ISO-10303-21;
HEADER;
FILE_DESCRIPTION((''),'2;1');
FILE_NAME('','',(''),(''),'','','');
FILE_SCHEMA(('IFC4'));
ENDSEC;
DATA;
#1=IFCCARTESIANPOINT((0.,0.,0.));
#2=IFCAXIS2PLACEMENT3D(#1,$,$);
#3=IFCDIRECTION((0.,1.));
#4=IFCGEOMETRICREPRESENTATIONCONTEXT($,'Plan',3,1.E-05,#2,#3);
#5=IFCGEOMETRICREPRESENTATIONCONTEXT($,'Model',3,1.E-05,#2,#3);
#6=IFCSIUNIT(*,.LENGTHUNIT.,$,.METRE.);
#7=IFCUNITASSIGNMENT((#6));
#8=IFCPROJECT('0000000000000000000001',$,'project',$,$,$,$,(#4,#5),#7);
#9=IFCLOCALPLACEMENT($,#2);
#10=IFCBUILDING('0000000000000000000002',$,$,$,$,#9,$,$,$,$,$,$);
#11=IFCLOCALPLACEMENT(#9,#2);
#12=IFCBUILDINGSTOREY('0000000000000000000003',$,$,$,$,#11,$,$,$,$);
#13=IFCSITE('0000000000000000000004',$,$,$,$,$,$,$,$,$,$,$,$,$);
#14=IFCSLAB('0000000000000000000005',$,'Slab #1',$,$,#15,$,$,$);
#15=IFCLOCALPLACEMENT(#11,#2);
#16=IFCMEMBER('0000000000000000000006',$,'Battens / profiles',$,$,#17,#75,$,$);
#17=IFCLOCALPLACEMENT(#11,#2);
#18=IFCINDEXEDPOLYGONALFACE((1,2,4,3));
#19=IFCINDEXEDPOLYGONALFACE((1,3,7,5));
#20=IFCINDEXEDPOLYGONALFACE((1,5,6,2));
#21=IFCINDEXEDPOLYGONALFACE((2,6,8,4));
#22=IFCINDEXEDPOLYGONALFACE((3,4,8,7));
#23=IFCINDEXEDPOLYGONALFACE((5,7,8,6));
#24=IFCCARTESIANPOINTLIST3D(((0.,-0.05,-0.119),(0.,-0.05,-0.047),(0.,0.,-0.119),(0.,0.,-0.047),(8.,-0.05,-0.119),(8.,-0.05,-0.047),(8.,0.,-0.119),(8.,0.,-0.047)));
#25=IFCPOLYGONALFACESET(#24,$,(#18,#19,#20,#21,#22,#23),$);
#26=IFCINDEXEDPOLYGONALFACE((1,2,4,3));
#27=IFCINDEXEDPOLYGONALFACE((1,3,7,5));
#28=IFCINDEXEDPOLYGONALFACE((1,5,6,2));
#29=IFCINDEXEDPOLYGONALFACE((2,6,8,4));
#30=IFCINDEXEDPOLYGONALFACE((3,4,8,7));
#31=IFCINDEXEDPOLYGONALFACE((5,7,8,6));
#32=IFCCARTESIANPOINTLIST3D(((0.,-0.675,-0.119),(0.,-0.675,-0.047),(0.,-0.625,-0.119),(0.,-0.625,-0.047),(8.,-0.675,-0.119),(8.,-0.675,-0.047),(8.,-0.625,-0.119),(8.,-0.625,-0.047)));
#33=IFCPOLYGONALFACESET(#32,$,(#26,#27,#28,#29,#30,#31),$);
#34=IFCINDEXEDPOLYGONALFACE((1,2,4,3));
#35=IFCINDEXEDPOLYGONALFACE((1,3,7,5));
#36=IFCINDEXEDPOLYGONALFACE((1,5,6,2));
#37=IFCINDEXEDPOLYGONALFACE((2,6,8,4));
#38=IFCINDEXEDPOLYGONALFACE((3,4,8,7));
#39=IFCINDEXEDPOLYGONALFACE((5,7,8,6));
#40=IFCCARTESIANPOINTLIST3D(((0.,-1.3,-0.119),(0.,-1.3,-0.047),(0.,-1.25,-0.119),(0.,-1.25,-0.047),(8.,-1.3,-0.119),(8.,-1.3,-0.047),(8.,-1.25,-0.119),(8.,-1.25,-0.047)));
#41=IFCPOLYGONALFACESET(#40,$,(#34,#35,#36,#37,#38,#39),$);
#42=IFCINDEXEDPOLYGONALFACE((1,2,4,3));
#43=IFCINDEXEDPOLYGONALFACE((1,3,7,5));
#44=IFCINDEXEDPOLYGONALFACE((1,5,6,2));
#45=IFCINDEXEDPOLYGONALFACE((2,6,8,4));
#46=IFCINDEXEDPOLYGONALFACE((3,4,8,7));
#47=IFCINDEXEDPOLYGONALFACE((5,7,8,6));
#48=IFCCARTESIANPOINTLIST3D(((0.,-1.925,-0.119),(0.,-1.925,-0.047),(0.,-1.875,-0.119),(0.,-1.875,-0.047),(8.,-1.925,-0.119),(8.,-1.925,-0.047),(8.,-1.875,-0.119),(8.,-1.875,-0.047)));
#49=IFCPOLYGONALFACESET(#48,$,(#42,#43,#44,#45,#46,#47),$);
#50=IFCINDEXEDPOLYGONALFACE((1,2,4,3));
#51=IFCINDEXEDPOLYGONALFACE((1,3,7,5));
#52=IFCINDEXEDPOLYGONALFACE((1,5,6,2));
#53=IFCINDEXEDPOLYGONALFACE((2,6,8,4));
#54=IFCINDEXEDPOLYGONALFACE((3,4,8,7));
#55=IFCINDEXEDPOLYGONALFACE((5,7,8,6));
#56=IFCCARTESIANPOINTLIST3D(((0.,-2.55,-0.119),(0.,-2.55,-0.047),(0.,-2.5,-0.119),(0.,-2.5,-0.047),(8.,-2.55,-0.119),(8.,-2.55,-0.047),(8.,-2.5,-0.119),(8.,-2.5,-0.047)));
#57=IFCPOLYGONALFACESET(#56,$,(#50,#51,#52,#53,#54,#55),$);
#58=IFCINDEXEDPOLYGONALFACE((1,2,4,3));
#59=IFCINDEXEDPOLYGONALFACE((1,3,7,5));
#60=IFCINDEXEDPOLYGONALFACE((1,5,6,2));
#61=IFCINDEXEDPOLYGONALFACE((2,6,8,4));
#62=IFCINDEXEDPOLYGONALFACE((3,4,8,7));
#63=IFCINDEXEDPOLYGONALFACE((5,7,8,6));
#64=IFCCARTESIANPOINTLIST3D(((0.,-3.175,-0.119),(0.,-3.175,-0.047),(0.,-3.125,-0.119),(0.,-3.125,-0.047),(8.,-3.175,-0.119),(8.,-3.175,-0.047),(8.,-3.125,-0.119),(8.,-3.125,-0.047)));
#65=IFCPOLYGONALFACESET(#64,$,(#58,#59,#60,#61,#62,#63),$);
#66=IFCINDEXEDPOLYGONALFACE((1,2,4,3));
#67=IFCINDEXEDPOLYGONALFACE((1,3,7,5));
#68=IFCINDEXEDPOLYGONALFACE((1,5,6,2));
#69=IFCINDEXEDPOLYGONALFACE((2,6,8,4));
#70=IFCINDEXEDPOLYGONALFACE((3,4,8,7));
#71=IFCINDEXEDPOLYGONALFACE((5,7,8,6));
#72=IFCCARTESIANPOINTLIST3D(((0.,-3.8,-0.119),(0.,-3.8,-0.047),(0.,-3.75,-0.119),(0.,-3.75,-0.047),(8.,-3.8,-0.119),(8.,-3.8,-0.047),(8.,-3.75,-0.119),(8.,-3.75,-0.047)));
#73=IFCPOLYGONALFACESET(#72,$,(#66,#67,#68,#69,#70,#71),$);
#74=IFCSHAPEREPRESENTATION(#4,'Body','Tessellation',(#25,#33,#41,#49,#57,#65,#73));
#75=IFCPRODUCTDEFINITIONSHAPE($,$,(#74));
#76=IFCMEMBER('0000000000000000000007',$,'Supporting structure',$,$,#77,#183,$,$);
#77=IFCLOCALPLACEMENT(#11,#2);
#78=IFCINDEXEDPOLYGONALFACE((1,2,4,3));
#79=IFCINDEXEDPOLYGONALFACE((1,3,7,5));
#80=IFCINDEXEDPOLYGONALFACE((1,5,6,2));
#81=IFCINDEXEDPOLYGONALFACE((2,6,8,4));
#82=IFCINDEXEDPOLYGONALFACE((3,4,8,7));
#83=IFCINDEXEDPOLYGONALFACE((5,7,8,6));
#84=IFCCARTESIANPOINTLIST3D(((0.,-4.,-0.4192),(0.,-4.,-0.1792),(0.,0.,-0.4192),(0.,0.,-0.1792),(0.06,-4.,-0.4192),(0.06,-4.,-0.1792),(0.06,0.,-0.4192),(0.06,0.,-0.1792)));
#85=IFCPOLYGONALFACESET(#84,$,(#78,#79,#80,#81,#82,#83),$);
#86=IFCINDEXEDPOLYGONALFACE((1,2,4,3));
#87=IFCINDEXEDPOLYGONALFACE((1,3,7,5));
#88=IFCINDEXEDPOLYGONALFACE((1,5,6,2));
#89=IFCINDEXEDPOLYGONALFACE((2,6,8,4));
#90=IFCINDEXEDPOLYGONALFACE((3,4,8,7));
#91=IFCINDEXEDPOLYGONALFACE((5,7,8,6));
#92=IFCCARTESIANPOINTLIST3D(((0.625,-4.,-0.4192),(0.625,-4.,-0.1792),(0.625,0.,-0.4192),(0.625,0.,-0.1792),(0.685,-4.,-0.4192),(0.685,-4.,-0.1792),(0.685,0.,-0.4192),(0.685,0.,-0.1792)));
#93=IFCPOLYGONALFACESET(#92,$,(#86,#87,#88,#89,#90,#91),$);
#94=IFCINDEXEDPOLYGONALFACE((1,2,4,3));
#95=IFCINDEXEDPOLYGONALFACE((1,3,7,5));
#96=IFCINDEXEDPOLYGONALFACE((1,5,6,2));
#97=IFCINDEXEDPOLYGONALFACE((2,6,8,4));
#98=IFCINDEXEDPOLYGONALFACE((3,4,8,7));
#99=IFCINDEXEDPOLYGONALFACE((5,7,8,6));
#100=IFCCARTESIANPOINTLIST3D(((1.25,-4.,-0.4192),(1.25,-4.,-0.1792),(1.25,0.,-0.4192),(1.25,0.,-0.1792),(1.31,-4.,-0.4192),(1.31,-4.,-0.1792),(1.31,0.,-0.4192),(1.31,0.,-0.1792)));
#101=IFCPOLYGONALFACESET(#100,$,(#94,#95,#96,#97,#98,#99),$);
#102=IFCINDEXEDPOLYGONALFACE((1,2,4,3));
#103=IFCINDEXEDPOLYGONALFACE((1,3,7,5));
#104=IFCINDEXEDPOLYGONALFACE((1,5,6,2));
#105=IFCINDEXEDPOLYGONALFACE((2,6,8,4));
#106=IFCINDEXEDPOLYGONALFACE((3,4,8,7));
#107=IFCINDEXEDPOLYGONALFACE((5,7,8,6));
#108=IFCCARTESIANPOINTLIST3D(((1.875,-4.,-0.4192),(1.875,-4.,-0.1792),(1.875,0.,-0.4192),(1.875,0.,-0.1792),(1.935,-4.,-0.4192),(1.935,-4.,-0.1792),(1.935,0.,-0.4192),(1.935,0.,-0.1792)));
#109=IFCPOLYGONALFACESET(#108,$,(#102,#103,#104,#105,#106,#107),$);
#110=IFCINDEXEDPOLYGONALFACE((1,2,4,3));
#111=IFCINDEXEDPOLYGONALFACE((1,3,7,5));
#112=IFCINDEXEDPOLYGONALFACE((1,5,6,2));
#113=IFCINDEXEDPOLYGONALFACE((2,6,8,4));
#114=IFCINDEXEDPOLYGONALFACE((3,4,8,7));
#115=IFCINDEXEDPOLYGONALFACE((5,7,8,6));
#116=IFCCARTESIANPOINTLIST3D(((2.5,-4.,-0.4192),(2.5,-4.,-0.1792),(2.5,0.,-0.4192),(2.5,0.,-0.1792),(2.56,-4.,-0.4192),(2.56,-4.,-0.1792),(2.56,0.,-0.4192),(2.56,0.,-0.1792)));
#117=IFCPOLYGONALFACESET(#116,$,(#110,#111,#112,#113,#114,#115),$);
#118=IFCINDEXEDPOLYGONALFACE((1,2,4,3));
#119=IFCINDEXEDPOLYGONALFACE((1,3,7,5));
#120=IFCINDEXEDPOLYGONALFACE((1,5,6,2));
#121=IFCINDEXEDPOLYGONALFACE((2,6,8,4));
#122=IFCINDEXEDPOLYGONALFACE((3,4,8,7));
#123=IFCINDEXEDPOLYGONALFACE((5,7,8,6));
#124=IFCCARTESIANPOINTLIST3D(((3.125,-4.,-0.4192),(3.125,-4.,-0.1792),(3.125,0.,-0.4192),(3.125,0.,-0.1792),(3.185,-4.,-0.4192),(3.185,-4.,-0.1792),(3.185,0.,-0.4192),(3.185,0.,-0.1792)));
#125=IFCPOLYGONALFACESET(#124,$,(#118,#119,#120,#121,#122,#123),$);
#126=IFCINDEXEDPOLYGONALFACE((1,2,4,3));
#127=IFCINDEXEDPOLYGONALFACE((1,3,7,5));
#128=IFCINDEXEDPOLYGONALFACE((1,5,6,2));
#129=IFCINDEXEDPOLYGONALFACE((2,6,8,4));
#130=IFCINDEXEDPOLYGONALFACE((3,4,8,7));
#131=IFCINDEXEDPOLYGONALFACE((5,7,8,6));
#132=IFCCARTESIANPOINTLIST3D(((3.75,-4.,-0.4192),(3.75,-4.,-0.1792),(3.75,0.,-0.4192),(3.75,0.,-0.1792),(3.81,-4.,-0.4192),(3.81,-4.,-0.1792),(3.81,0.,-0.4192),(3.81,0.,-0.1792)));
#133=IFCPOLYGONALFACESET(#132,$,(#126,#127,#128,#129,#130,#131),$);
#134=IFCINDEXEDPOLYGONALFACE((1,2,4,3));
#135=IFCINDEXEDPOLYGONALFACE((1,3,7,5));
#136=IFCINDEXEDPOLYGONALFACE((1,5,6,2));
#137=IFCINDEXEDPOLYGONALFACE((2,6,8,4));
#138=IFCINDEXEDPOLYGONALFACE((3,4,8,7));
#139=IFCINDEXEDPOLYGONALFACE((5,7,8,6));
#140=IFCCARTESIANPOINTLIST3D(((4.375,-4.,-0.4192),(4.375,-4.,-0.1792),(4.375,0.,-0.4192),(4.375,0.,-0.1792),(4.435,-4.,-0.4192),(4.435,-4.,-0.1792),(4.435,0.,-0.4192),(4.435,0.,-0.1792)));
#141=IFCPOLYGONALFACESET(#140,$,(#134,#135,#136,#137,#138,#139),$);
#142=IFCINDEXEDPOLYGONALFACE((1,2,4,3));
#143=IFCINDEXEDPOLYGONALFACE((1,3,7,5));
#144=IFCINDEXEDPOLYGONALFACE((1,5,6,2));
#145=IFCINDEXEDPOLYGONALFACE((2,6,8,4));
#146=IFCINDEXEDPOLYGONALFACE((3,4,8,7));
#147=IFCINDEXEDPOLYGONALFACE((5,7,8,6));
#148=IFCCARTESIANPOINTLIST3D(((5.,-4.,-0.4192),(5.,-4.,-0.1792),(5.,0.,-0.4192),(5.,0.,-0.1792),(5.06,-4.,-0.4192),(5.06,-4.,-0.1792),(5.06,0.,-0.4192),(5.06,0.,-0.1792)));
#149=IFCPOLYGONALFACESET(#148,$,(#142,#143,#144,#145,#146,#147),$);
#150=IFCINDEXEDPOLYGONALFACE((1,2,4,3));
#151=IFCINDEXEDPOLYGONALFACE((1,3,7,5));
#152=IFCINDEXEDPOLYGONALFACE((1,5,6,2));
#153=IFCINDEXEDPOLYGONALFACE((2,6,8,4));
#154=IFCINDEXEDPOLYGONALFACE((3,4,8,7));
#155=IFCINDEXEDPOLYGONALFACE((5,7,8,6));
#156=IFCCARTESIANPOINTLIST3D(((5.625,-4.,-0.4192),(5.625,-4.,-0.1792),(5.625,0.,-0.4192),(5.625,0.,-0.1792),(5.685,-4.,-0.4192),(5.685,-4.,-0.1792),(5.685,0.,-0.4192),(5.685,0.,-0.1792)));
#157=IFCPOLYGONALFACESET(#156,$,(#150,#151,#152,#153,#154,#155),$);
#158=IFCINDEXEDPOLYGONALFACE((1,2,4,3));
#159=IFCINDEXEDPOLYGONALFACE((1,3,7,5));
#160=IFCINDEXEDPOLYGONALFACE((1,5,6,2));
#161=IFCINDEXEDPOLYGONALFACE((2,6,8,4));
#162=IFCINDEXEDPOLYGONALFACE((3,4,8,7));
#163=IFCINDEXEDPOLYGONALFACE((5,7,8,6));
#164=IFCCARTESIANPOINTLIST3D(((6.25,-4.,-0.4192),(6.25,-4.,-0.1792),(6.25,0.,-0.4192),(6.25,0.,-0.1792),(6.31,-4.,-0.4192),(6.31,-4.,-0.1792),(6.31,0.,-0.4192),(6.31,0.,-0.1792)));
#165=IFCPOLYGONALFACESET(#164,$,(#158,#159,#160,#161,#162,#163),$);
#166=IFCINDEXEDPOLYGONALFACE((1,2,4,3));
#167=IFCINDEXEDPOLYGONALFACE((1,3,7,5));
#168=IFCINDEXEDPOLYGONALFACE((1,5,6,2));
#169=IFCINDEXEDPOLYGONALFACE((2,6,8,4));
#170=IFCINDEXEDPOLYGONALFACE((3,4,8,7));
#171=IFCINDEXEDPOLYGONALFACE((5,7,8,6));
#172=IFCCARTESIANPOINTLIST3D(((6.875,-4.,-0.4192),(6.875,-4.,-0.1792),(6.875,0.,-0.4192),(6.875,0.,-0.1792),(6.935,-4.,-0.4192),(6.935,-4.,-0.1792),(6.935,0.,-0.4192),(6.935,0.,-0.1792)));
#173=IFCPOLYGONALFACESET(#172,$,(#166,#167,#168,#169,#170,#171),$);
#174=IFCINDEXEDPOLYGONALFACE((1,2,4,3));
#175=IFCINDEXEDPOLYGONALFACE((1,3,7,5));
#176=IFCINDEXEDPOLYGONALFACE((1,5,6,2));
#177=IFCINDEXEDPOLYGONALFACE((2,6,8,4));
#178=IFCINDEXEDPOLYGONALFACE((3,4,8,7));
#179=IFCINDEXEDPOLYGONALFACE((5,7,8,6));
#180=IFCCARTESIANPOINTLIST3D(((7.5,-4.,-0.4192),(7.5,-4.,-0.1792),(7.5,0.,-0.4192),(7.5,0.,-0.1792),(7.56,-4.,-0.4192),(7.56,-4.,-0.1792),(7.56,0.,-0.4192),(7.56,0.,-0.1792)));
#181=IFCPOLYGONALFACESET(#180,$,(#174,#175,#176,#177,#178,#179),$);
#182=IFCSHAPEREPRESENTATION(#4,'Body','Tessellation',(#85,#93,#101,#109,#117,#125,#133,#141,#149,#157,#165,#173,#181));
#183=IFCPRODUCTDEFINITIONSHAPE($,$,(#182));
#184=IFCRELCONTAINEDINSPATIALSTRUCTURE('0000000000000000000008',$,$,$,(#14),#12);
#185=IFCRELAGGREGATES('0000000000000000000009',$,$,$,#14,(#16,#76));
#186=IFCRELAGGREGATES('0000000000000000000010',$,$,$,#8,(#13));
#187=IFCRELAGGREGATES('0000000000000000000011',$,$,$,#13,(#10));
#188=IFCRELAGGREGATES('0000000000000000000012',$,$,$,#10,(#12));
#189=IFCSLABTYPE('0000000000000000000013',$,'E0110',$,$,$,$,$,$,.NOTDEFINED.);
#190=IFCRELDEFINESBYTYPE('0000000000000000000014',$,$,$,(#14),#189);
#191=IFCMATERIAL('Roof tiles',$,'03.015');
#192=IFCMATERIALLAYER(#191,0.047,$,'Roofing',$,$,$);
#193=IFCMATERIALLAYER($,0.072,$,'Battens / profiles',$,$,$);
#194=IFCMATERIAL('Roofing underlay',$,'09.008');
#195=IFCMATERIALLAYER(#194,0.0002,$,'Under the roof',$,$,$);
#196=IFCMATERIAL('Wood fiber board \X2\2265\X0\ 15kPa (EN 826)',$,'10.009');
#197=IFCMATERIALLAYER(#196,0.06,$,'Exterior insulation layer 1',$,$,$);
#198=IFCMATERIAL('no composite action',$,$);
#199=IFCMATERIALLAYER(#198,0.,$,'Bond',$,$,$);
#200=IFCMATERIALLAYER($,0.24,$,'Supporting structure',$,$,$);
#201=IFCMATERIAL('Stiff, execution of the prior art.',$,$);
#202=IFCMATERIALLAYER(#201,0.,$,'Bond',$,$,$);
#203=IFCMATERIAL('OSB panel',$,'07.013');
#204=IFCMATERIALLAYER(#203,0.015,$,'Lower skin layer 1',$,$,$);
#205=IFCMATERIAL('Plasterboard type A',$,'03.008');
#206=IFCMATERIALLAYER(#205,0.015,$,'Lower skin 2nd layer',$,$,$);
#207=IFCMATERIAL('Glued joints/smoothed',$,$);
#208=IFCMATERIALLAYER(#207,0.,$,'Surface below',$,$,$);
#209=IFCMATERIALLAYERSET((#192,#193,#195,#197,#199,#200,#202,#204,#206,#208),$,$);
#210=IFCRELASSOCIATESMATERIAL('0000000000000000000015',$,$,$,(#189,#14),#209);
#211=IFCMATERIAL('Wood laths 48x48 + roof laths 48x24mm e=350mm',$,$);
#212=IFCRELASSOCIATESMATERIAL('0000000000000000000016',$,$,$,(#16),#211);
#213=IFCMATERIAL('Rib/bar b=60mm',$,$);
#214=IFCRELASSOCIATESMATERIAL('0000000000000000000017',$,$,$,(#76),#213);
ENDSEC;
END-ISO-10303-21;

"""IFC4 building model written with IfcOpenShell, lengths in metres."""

from ifc_helpers import new_model, si_unit, direction, frame, frame_2d, origin, place, context, project, spatial, rectangle, extrude, material, layer, layer_set, type_object, element, aggregate, save


model = new_model("IFC4")

# Units and contexts
plan_context = context("Plan", 3, precision=1e-05, world=origin(), true_north=direction((0.0, 1.0)))
model_context = context("Model", 3, precision=1e-05, world=origin(), true_north=direction((0.0, 1.0)))
ifc_project = project(units=[si_unit("LENGTHUNIT", "METRE")], contexts=[plan_context, model_context])

# Site, building, storey
site = spatial("IfcSite", under=ifc_project)
building_placement = place(None, origin())
building = spatial("IfcBuilding", under=site, at=building_placement)
storey_placement = place(building_placement, origin())
storey = spatial("IfcBuildingStorey", under=building, at=storey_placement)

# Slab, members
ifc_material_1 = material(Name="Roof tiles", Category="03.015")
ifc_layer_1 = layer(ifc_material_1, 0.047, Name="Roofing")
ifc_layer_2 = layer(None, 0.072, Name="Battens / profiles")
ifc_material_2 = material(Name="Roofing underlay", Category="09.008")
ifc_layer_3 = layer(ifc_material_2, 0.0002, Name="Under the roof")
ifc_material_3 = material(Name="Wood fiber board ≥ 15kPa (EN 826)", Category="10.009")
ifc_layer_4 = layer(ifc_material_3, 0.06, Name="Exterior insulation layer 1")
ifc_material_4 = material(Name="no composite action")
ifc_layer_5 = layer(ifc_material_4, 0.0, Name="Bond")
ifc_layer_6 = layer(None, 0.24, Name="Supporting structure")
ifc_material_5 = material(Name="Stiff, execution of the prior art.")
ifc_layer_7 = layer(ifc_material_5, 0.0, Name="Bond")
ifc_material_6 = material(Name="OSB panel", Category="07.013")
ifc_layer_8 = layer(ifc_material_6, 0.015, Name="Lower skin layer 1")
ifc_material_7 = material(Name="Plasterboard type A", Category="03.008")
ifc_layer_9 = layer(ifc_material_7, 0.015, Name="Lower skin 2nd layer")
ifc_material_8 = material(Name="Glued joints/smoothed")
ifc_layer_10 = layer(ifc_material_8, 0.0, Name="Surface below")
ifc_layer_set = layer_set([ifc_layer_1, ifc_layer_2, ifc_layer_3, ifc_layer_4, ifc_layer_5, ifc_layer_6, ifc_layer_7, ifc_layer_8, ifc_layer_9, ifc_layer_10])
slab_type = type_object("IfcSlabType", Name="E0110", PredefinedType="NOTDEFINED", material=ifc_layer_set)
slab_placement = place(None, frame((0.0, 0.0, 0.0), z_axis=(0.0, 0.0, -1.0), x_axis=(1.0, 0.0, 0.0)))
slab = element("IfcSlab", 1, at=slab_placement, inside=storey, type_object=slab_type, material=ifc_layer_set, Name="Slab #1")
ifc_material_9 = material(Name="Wood laths 48x48 + roof laths 48x24mm e=350mm")
member_1_placement = place(slab_placement, origin())
member_1 = element("IfcMember", 2, at=member_1_placement, material=ifc_material_9, Name="Battens / profiles", context=plan_context, shape_type="SweptSolid", body=[
    extrude(rectangle(XDim=0.05, YDim=0.072, at=frame_2d((0.025, 0.036), x_axis=(1.0, 0.0))), frame((0.0, 0.0, 0.047), z_axis=(1.0, 0.0, 0.0), x_axis=(0.0, 1.0, 0.0)), (0.0, 0.0, 1.0), 8.0),
    extrude(rectangle(XDim=0.05, YDim=0.072, at=frame_2d((0.025, 0.036), x_axis=(1.0, 0.0))), frame((0.0, 0.625, 0.047), z_axis=(1.0, 0.0, 0.0), x_axis=(0.0, 1.0, 0.0)), (0.0, 0.0, 1.0), 8.0),
    extrude(rectangle(XDim=0.05, YDim=0.072, at=frame_2d((0.025, 0.036), x_axis=(1.0, 0.0))), frame((0.0, 1.25, 0.047), z_axis=(1.0, 0.0, 0.0), x_axis=(0.0, 1.0, 0.0)), (0.0, 0.0, 1.0), 8.0),
    extrude(rectangle(XDim=0.05, YDim=0.072, at=frame_2d((0.025, 0.036), x_axis=(1.0, 0.0))), frame((0.0, 1.875, 0.047), z_axis=(1.0, 0.0, 0.0), x_axis=(0.0, 1.0, 0.0)), (0.0, 0.0, 1.0), 8.0),
    extrude(rectangle(XDim=0.05, YDim=0.072, at=frame_2d((0.025, 0.036), x_axis=(1.0, 0.0))), frame((0.0, 2.5, 0.047), z_axis=(1.0, 0.0, 0.0), x_axis=(0.0, 1.0, 0.0)), (0.0, 0.0, 1.0), 8.0),
    extrude(rectangle(XDim=0.05, YDim=0.072, at=frame_2d((0.025, 0.036), x_axis=(1.0, 0.0))), frame((0.0, 3.125, 0.047), z_axis=(1.0, 0.0, 0.0), x_axis=(0.0, 1.0, 0.0)), (0.0, 0.0, 1.0), 8.0),
    extrude(rectangle(XDim=0.05, YDim=0.072, at=frame_2d((0.025, 0.036), x_axis=(1.0, 0.0))), frame((0.0, 3.75, 0.047), z_axis=(1.0, 0.0, 0.0), x_axis=(0.0, 1.0, 0.0)), (0.0, 0.0, 1.0), 8.0),
])
ifc_material_10 = material(Name="Rib/bar b=60mm")
member_2_placement = place(slab_placement, origin())
member_2 = element("IfcMember", 3, at=member_2_placement, material=ifc_material_10, Name="Supporting structure", context=plan_context, shape_type="SweptSolid", body=[
    extrude(rectangle(XDim=0.06, YDim=0.24, at=frame_2d((0.03, 0.12), x_axis=(1.0, 0.0))), frame((0.0, 4.0, 0.1792), z_axis=(0.0, -1.0, 0.0), x_axis=(1.0, 0.0, 0.0)), (0.0, 0.0, 1.0), 4.0),
    extrude(rectangle(XDim=0.06, YDim=0.24, at=frame_2d((0.03, 0.12), x_axis=(1.0, 0.0))), frame((0.625, 4.0, 0.1792), z_axis=(0.0, -1.0, 0.0), x_axis=(1.0, 0.0, 0.0)), (0.0, 0.0, 1.0), 4.0),
    extrude(rectangle(XDim=0.06, YDim=0.24, at=frame_2d((0.03, 0.12), x_axis=(1.0, 0.0))), frame((1.25, 4.0, 0.1792), z_axis=(0.0, -1.0, 0.0), x_axis=(1.0, 0.0, 0.0)), (0.0, 0.0, 1.0), 4.0),
    extrude(rectangle(XDim=0.06, YDim=0.24, at=frame_2d((0.03, 0.12), x_axis=(1.0, 0.0))), frame((1.875, 4.0, 0.1792), z_axis=(0.0, -1.0, 0.0), x_axis=(1.0, 0.0, 0.0)), (0.0, 0.0, 1.0), 4.0),
    extrude(rectangle(XDim=0.06, YDim=0.24, at=frame_2d((0.03, 0.12), x_axis=(1.0, 0.0))), frame((2.5, 4.0, 0.1792), z_axis=(0.0, -1.0, 0.0), x_axis=(1.0, 0.0, 0.0)), (0.0, 0.0, 1.0), 4.0),
    extrude(rectangle(XDim=0.06, YDim=0.24, at=frame_2d((0.03, 0.12), x_axis=(1.0, 0.0))), frame((3.125, 4.0, 0.1792), z_axis=(0.0, -1.0, 0.0), x_axis=(1.0, 0.0, 0.0)), (0.0, 0.0, 1.0), 4.0),
    extrude(rectangle(XDim=0.06, YDim=0.24, at=frame_2d((0.03, 0.12), x_axis=(1.0, 0.0))), frame((3.75, 4.0, 0.1792), z_axis=(0.0, -1.0, 0.0), x_axis=(1.0, 0.0, 0.0)), (0.0, 0.0, 1.0), 4.0),
    extrude(rectangle(XDim=0.06, YDim=0.24, at=frame_2d((0.03, 0.12), x_axis=(1.0, 0.0))), frame((4.375, 4.0, 0.1792), z_axis=(0.0, -1.0, 0.0), x_axis=(1.0, 0.0, 0.0)), (0.0, 0.0, 1.0), 4.0),
    extrude(rectangle(XDim=0.06, YDim=0.24, at=frame_2d((0.03, 0.12), x_axis=(1.0, 0.0))), frame((5.0, 4.0, 0.1792), z_axis=(0.0, -1.0, 0.0), x_axis=(1.0, 0.0, 0.0)), (0.0, 0.0, 1.0), 4.0),
    extrude(rectangle(XDim=0.06, YDim=0.24, at=frame_2d((0.03, 0.12), x_axis=(1.0, 0.0))), frame((5.625, 4.0, 0.1792), z_axis=(0.0, -1.0, 0.0), x_axis=(1.0, 0.0, 0.0)), (0.0, 0.0, 1.0), 4.0),
    extrude(rectangle(XDim=0.06, YDim=0.24, at=frame_2d((0.03, 0.12), x_axis=(1.0, 0.0))), frame((6.25, 4.0, 0.1792), z_axis=(0.0, -1.0, 0.0), x_axis=(1.0, 0.0, 0.0)), (0.0, 0.0, 1.0), 4.0),
    extrude(rectangle(XDim=0.06, YDim=0.24, at=frame_2d((0.03, 0.12), x_axis=(1.0, 0.0))), frame((6.875, 4.0, 0.1792), z_axis=(0.0, -1.0, 0.0), x_axis=(1.0, 0.0, 0.0)), (0.0, 0.0, 1.0), 4.0),
    extrude(rectangle(XDim=0.06, YDim=0.24, at=frame_2d((0.03, 0.12), x_axis=(1.0, 0.0))), frame((7.5, 4.0, 0.1792), z_axis=(0.0, -1.0, 0.0), x_axis=(1.0, 0.0, 0.0)), (0.0, 0.0, 1.0), 4.0),
])
aggregate(slab, [member_1, member_2])

save(model, "model.ifc")
